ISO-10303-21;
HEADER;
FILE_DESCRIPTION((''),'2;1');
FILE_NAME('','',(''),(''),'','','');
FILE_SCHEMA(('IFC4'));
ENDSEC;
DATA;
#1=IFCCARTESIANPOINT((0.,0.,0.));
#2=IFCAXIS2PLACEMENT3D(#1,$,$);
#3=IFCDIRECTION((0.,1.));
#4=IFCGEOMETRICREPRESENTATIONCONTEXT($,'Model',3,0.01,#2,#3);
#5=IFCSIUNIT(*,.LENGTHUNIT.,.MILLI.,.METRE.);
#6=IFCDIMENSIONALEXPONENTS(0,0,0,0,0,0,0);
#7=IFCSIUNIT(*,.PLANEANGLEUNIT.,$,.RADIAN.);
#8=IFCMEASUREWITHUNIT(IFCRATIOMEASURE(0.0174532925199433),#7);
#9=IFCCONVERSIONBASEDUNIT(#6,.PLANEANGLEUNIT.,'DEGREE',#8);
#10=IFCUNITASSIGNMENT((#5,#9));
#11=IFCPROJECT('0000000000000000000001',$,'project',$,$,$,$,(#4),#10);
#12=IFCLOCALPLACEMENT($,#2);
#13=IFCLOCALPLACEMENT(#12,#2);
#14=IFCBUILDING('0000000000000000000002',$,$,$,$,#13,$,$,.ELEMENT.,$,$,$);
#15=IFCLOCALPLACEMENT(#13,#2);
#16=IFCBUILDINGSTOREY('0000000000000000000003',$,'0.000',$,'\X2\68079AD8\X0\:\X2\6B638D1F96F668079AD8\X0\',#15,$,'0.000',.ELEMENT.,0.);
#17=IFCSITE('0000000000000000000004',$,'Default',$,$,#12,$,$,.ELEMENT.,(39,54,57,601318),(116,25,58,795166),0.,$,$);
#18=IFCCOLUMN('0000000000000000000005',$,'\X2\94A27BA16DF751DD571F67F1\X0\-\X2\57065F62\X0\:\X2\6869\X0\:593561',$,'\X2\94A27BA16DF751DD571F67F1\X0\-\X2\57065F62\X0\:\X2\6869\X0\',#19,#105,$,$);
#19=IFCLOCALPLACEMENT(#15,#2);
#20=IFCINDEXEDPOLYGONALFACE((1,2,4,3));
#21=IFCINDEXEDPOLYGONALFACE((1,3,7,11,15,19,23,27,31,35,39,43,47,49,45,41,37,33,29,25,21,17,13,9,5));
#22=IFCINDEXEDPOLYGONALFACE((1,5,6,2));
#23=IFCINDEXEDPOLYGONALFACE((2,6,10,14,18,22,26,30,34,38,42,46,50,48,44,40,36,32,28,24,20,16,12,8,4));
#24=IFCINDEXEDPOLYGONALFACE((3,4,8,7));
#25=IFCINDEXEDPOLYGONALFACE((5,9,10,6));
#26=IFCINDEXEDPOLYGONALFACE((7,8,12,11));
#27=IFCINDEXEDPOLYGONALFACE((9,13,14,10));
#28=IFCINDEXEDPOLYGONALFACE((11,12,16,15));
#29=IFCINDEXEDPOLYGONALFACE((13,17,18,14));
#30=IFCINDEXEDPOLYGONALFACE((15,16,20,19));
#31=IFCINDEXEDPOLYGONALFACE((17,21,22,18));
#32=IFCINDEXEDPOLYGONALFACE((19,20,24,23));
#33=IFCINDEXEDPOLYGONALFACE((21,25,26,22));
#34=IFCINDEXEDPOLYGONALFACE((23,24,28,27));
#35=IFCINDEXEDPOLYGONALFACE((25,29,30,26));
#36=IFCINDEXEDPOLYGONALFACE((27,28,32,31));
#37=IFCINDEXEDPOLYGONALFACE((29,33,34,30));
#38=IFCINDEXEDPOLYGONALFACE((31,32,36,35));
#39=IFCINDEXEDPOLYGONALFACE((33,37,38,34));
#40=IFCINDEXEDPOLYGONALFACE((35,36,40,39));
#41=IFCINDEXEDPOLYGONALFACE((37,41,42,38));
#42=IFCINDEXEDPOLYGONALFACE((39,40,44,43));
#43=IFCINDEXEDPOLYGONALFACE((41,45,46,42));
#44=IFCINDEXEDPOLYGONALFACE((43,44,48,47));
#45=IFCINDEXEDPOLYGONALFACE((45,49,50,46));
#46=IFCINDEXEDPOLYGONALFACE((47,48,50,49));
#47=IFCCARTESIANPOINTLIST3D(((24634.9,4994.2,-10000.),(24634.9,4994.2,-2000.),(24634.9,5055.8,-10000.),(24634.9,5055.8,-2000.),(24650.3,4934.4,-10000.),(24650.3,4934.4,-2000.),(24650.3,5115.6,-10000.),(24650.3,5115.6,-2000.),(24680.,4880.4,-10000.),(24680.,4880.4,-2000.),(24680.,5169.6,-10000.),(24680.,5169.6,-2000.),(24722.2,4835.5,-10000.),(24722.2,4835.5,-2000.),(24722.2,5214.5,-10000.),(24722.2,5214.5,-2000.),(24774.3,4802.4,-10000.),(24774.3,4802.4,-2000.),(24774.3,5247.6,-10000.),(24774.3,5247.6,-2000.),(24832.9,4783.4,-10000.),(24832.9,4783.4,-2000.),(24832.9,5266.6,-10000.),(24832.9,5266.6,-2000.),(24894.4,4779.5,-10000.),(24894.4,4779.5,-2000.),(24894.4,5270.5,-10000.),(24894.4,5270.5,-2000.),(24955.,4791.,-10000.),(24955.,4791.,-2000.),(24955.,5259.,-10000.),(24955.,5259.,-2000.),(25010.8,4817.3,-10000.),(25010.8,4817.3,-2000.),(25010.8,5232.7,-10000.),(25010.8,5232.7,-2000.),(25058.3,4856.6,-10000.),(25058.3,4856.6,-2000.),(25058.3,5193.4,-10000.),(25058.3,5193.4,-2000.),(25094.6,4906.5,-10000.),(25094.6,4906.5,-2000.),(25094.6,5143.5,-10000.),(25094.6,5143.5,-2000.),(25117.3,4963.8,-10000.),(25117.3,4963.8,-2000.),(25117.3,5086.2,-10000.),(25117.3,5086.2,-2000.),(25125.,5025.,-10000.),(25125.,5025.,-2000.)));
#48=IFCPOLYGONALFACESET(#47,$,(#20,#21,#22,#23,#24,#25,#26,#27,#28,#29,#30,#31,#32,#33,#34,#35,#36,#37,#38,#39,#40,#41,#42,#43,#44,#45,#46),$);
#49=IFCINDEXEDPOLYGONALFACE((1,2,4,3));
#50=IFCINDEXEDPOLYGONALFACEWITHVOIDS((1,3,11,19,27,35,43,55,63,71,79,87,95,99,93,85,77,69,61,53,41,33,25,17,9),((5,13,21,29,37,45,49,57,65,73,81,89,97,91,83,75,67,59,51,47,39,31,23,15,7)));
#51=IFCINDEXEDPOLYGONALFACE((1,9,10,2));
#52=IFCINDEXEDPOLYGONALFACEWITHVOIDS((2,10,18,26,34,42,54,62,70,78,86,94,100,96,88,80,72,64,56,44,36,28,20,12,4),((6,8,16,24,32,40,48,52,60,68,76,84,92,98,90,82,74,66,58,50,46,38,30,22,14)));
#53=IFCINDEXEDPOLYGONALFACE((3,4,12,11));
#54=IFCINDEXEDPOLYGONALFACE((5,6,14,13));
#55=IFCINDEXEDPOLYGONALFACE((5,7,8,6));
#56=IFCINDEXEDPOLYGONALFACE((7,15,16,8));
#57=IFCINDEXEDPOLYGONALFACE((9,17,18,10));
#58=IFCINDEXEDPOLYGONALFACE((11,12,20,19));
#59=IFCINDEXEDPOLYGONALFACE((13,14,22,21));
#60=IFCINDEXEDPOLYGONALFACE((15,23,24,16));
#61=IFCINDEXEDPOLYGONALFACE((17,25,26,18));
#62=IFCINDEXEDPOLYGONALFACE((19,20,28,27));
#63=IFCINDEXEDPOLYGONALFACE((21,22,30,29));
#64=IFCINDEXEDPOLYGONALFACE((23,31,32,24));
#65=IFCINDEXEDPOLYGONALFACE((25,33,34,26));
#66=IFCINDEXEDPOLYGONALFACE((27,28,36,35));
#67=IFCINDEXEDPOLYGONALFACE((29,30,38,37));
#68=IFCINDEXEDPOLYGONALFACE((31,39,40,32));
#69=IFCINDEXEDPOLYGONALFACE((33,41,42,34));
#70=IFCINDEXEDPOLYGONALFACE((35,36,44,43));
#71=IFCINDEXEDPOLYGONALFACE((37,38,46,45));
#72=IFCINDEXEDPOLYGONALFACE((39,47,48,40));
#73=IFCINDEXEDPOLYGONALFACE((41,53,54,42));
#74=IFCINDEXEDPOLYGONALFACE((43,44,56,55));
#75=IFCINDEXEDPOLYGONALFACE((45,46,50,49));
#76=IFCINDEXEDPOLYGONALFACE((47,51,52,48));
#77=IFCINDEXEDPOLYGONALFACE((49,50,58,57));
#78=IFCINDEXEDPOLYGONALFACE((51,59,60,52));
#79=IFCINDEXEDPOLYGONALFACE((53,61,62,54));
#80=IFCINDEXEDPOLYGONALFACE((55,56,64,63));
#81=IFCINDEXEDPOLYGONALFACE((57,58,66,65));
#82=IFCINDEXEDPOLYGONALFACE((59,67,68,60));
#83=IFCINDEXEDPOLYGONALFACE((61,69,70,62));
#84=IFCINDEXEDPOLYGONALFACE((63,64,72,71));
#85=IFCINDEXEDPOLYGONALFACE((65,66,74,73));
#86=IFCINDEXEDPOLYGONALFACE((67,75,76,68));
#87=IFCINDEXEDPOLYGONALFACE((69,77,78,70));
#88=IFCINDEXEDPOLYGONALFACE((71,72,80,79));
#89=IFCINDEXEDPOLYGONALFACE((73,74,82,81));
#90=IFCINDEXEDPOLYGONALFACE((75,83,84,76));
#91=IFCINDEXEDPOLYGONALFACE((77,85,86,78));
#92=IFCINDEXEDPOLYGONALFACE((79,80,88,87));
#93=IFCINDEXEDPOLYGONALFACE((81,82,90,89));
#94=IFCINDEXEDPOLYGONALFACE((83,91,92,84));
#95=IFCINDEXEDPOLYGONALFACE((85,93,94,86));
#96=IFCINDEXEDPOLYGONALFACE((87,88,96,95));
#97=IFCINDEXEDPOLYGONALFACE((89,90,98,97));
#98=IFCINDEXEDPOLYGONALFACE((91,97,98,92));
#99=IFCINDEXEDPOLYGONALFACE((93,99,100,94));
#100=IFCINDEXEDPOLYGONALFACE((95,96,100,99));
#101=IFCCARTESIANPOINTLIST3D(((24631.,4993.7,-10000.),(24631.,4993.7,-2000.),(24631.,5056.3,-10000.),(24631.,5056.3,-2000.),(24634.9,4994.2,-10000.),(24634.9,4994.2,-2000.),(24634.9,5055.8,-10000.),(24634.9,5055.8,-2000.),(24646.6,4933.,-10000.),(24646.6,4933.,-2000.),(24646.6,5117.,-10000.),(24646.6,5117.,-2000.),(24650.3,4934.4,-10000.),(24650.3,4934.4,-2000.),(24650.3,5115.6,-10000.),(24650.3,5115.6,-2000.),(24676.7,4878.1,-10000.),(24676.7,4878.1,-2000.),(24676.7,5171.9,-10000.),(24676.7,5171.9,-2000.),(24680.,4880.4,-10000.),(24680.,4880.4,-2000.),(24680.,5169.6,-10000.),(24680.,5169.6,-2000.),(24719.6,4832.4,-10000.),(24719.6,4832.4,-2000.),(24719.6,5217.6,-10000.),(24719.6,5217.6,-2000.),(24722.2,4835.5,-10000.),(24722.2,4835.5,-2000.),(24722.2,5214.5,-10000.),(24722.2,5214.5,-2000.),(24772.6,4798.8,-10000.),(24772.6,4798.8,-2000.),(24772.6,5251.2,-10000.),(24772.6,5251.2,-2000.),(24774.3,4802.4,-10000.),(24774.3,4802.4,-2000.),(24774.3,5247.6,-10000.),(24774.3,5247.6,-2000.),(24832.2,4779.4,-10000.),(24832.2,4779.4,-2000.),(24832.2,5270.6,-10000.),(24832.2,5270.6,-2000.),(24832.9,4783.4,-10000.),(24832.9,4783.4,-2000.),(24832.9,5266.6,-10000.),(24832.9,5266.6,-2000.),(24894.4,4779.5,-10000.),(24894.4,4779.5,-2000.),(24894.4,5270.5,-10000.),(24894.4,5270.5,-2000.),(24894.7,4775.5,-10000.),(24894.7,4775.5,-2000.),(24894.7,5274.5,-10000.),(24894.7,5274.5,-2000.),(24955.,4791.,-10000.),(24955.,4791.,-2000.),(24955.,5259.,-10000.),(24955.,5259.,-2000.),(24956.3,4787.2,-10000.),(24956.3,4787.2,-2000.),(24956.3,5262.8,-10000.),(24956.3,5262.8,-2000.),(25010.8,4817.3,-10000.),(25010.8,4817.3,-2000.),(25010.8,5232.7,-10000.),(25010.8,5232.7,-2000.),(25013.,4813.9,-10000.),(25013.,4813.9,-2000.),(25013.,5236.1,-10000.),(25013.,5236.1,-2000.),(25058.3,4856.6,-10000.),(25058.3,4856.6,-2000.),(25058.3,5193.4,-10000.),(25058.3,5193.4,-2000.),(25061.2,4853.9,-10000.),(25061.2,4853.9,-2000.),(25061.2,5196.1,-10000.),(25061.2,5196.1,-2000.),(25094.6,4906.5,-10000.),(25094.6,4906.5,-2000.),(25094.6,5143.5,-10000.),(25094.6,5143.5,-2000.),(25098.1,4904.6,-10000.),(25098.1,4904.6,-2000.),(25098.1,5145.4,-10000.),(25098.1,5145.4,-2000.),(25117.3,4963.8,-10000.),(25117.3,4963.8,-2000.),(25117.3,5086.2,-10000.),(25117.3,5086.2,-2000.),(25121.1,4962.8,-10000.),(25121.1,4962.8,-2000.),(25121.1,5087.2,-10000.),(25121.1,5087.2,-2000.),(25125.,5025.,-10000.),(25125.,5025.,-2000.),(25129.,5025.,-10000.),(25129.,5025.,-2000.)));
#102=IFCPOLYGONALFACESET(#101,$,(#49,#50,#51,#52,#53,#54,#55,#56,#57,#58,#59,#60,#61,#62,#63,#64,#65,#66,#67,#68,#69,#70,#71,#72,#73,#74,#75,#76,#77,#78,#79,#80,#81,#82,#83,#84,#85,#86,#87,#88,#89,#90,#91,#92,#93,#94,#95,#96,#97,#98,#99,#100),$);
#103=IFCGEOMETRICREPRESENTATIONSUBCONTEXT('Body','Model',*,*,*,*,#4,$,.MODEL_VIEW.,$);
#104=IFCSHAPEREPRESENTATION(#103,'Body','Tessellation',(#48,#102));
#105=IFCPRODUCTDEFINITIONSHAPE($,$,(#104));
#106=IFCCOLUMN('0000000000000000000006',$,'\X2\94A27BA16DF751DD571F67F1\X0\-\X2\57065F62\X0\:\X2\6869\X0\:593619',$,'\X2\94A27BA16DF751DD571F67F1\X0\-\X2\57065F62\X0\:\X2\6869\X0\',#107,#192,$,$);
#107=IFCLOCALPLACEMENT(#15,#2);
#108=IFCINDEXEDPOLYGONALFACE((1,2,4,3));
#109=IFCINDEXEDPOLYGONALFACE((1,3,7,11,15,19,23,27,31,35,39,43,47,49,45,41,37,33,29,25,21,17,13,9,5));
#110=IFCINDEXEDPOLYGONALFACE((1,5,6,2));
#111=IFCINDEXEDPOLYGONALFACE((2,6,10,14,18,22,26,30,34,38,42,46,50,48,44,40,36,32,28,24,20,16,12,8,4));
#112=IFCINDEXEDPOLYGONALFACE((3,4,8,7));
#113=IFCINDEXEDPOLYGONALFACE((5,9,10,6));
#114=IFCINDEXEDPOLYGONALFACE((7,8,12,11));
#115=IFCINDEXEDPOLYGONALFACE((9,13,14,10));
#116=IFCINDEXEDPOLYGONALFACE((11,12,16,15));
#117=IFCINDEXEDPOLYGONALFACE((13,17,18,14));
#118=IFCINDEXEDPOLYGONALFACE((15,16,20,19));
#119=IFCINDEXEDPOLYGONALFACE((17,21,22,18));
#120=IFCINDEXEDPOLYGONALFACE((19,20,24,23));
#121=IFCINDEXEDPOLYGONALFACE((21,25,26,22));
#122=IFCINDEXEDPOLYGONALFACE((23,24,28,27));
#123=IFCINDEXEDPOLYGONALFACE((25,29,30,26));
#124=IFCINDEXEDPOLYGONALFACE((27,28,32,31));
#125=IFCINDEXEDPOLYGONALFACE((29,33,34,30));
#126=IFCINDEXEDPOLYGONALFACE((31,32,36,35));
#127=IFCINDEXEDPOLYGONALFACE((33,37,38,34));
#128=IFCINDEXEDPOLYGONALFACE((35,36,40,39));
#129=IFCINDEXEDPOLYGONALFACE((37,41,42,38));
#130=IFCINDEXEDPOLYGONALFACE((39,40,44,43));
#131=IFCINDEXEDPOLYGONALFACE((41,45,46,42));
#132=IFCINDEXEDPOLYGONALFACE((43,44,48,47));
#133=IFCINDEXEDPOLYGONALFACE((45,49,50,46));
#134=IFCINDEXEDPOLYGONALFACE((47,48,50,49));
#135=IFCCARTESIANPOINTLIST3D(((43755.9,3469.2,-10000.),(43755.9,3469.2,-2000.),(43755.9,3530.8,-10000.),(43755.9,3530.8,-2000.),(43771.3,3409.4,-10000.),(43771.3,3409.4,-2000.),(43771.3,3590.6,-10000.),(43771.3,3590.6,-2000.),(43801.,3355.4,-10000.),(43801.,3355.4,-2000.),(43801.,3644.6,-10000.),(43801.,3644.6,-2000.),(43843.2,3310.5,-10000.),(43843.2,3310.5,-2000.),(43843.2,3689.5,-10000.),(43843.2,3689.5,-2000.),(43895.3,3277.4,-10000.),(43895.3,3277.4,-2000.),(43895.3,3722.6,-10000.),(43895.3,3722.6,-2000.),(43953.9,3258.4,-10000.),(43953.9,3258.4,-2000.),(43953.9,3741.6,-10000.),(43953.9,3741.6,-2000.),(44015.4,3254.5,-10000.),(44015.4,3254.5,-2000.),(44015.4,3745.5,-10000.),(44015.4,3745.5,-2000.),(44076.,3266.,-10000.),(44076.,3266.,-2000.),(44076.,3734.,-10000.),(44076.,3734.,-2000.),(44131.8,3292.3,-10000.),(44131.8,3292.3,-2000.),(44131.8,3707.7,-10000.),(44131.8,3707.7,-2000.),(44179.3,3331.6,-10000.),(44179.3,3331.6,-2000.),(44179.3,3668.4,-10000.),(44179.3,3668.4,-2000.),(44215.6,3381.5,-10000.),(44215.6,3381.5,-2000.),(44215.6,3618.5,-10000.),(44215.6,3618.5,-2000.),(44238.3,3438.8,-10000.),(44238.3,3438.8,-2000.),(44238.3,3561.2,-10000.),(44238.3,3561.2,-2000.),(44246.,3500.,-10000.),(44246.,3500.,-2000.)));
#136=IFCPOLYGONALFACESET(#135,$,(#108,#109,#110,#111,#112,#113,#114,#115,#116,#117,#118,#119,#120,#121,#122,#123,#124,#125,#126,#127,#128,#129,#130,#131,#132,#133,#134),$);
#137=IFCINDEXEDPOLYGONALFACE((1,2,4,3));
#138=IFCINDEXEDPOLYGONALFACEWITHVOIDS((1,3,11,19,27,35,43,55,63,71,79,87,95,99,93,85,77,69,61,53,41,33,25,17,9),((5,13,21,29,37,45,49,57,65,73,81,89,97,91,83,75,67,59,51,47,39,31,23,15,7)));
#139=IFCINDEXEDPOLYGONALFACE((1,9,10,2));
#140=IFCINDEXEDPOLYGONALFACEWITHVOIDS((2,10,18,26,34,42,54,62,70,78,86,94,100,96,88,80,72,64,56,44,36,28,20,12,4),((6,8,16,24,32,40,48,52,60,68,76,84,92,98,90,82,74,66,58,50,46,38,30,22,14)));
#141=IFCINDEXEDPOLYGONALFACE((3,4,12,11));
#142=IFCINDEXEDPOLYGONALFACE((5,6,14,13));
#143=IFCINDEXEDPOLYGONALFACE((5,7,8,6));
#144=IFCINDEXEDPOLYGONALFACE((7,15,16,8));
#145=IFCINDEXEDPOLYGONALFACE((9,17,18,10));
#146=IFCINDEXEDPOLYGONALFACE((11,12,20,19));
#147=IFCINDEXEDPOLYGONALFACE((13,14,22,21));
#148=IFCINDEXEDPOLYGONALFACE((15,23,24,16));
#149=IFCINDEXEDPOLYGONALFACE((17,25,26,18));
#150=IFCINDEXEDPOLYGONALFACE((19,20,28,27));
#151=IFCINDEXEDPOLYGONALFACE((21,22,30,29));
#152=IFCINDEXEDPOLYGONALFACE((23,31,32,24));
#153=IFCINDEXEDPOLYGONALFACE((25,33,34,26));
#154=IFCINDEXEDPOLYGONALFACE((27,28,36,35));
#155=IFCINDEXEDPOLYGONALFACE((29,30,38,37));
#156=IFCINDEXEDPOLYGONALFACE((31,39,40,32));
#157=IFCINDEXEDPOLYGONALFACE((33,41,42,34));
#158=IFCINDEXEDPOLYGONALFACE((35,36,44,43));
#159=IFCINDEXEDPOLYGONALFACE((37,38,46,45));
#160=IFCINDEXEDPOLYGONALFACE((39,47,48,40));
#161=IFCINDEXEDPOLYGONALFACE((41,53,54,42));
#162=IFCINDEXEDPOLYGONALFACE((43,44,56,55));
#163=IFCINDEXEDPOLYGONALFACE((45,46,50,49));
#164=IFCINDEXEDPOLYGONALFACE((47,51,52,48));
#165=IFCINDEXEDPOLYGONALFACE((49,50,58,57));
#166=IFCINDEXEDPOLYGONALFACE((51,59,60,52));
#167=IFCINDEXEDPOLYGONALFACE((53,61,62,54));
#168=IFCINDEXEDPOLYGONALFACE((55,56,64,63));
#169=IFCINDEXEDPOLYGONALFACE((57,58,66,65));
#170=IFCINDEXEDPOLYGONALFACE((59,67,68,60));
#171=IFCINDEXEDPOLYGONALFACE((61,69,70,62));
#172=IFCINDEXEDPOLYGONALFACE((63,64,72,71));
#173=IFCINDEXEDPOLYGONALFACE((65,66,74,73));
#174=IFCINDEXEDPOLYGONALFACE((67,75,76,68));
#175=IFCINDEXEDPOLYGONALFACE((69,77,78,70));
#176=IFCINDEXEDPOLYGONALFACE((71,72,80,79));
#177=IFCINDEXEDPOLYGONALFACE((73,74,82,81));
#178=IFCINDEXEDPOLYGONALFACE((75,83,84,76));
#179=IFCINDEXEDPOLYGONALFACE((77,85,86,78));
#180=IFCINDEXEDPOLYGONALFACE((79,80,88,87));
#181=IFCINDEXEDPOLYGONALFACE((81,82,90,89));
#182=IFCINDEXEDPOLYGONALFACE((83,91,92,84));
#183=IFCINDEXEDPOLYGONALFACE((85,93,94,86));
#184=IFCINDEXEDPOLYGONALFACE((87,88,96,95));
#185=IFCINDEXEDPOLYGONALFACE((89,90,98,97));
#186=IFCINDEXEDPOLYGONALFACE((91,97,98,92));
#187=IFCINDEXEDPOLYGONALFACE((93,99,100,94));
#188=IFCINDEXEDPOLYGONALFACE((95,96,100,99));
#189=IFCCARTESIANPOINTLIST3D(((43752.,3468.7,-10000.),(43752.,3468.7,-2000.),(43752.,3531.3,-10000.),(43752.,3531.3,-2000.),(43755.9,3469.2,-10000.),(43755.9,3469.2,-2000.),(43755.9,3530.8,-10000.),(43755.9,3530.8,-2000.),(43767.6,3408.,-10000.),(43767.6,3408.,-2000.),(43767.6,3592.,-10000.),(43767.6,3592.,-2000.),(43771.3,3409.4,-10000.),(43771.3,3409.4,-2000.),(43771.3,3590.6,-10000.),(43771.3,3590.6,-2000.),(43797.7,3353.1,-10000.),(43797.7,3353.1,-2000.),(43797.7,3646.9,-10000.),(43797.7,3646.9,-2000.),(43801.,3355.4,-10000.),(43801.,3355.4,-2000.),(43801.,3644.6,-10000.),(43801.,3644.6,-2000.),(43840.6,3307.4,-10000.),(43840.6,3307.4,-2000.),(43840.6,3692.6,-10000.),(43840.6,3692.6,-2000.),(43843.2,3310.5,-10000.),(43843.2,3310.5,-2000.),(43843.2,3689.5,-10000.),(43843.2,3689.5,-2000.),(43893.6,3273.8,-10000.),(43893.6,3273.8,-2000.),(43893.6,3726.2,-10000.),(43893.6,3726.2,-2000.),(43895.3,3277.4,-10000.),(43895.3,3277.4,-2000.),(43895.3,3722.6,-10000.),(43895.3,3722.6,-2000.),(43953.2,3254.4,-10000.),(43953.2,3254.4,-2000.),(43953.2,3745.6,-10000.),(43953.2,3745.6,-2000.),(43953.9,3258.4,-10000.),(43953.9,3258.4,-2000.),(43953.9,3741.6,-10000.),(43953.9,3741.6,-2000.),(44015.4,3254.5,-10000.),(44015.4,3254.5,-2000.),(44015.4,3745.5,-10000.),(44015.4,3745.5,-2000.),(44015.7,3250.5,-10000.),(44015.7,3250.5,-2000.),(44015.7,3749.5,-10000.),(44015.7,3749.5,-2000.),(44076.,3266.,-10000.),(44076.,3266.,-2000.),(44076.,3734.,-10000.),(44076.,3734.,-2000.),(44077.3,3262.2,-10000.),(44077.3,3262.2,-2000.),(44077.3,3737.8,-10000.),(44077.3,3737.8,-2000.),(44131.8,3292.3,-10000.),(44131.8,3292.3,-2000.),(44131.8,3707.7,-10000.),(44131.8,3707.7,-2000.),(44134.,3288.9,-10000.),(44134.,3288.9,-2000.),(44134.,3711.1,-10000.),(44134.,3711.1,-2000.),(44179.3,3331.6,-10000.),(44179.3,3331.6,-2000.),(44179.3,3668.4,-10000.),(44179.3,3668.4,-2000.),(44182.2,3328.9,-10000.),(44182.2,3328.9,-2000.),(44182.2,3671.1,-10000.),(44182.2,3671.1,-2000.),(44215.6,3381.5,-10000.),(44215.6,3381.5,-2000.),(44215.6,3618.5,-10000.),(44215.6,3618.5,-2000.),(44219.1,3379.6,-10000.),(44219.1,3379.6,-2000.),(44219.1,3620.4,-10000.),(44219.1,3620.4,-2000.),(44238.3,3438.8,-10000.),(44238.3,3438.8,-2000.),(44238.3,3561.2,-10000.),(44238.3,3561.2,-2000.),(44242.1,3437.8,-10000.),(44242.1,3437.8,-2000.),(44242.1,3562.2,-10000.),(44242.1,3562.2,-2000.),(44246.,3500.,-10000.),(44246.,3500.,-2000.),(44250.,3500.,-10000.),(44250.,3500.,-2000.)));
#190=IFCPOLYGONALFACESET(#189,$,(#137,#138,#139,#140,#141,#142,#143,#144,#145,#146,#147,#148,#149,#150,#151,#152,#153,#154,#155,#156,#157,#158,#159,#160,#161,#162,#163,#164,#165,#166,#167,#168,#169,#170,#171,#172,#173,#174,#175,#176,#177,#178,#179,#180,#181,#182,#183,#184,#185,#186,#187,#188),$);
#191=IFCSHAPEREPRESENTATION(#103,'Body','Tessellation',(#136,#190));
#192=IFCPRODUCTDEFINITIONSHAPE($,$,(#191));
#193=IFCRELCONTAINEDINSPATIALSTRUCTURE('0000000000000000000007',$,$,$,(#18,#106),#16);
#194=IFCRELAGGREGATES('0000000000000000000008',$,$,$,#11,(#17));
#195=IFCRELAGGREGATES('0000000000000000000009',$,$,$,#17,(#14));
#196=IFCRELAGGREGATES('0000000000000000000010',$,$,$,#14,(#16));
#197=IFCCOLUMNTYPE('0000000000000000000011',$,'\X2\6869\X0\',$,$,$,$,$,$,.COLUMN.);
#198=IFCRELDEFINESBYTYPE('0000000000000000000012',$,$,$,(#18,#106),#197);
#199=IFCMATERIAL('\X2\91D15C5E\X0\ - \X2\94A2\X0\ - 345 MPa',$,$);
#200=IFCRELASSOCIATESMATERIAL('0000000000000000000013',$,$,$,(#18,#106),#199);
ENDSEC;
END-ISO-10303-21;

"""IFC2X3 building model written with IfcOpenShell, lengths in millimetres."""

from ifc_helpers import new_model, entity, si_unit, converted_unit, direction, frame, frame_2d, origin, place, context, subcontext, project, spatial, circle, hollow_circle, extrude, source, transform, mapped, material, type_object, type_shapes, element, save


model = new_model("IFC2X3")

# Units and contexts
model_context = context("Model", 3, precision=0.01, world=origin(), true_north=direction((0.0, 1.0)))
body_context = subcontext(model_context, "Body", "Model", "MODEL_VIEW")
ifc_project = project(units=[si_unit("LENGTHUNIT", "METRE", prefix="MILLI"), converted_unit("PLANEANGLEUNIT", "DEGREE", entity("IfcRatioMeasure", 0.0174532925199433), si_unit("PLANEANGLEUNIT", "RADIAN"), dimensions=[0, 0, 0, 0, 0, 0, 0])], contexts=[model_context])

# Site, building, storey
site_placement = place(None, origin())
site = spatial("IfcSite", under=ifc_project, at=site_placement, Name="Default", CompositionType="ELEMENT", RefLatitude=(39, 54, 57, 601318), RefLongitude=(116, 25, 58, 795166), RefElevation=0.0)
building_placement = place(site_placement, origin())
building = spatial("IfcBuilding", under=site, at=building_placement, CompositionType="ELEMENT")
storey_placement = place(building_placement, origin())
storey = spatial("IfcBuildingStorey", under=building, at=storey_placement, Name="0.000", ObjectType="标高:正负零标高", LongName="0.000", CompositionType="ELEMENT", Elevation=0.0)

# Columns
ifc_material_1 = material(Name="金属 - 钢 - 345 MPa")
column_type = type_object("IfcColumnType", Name="桩", PredefinedType="COLUMN")
shared_shape = source(origin(), body_context, "Body", "SweptSolid", [
    extrude(circle(Radius=246.0, at=frame_2d((0.0, 0.0), x_axis=(1.0, 0.0))), frame((0.0, 0.0, -10000.0)), (0.0, 0.0, 1.0), 8000.0),
    extrude(hollow_circle(Radius=250.0, WallThickness=4.0, at=frame_2d((0.0, 0.0), x_axis=(1.0, 0.0))), frame((0.0, 0.0, -10000.0)), (0.0, 0.0, 1.0), 8000.0),
])
type_shapes(column_type, [shared_shape])
for number, where, name in (
    (1, (24879.0, 5025.0, 0.0), "钢管混凝土柱-圆形:桩:593561"),
    (2, (44000.0, 3500.0, 0.0), "钢管混凝土柱-圆形:桩:593619"),
):
    element("IfcColumn", number, at=place(storey_placement, frame(where)), inside=storey, type_object=column_type, material=ifc_material_1, Name=name, ObjectType="钢管混凝土柱-圆形:桩", context=body_context, shape_type="MappedRepresentation", body=[
        mapped(shared_shape, transform((0.0, 0.0, 0.0), scale=1.0)),
    ])

save(model, "model.ifc")
